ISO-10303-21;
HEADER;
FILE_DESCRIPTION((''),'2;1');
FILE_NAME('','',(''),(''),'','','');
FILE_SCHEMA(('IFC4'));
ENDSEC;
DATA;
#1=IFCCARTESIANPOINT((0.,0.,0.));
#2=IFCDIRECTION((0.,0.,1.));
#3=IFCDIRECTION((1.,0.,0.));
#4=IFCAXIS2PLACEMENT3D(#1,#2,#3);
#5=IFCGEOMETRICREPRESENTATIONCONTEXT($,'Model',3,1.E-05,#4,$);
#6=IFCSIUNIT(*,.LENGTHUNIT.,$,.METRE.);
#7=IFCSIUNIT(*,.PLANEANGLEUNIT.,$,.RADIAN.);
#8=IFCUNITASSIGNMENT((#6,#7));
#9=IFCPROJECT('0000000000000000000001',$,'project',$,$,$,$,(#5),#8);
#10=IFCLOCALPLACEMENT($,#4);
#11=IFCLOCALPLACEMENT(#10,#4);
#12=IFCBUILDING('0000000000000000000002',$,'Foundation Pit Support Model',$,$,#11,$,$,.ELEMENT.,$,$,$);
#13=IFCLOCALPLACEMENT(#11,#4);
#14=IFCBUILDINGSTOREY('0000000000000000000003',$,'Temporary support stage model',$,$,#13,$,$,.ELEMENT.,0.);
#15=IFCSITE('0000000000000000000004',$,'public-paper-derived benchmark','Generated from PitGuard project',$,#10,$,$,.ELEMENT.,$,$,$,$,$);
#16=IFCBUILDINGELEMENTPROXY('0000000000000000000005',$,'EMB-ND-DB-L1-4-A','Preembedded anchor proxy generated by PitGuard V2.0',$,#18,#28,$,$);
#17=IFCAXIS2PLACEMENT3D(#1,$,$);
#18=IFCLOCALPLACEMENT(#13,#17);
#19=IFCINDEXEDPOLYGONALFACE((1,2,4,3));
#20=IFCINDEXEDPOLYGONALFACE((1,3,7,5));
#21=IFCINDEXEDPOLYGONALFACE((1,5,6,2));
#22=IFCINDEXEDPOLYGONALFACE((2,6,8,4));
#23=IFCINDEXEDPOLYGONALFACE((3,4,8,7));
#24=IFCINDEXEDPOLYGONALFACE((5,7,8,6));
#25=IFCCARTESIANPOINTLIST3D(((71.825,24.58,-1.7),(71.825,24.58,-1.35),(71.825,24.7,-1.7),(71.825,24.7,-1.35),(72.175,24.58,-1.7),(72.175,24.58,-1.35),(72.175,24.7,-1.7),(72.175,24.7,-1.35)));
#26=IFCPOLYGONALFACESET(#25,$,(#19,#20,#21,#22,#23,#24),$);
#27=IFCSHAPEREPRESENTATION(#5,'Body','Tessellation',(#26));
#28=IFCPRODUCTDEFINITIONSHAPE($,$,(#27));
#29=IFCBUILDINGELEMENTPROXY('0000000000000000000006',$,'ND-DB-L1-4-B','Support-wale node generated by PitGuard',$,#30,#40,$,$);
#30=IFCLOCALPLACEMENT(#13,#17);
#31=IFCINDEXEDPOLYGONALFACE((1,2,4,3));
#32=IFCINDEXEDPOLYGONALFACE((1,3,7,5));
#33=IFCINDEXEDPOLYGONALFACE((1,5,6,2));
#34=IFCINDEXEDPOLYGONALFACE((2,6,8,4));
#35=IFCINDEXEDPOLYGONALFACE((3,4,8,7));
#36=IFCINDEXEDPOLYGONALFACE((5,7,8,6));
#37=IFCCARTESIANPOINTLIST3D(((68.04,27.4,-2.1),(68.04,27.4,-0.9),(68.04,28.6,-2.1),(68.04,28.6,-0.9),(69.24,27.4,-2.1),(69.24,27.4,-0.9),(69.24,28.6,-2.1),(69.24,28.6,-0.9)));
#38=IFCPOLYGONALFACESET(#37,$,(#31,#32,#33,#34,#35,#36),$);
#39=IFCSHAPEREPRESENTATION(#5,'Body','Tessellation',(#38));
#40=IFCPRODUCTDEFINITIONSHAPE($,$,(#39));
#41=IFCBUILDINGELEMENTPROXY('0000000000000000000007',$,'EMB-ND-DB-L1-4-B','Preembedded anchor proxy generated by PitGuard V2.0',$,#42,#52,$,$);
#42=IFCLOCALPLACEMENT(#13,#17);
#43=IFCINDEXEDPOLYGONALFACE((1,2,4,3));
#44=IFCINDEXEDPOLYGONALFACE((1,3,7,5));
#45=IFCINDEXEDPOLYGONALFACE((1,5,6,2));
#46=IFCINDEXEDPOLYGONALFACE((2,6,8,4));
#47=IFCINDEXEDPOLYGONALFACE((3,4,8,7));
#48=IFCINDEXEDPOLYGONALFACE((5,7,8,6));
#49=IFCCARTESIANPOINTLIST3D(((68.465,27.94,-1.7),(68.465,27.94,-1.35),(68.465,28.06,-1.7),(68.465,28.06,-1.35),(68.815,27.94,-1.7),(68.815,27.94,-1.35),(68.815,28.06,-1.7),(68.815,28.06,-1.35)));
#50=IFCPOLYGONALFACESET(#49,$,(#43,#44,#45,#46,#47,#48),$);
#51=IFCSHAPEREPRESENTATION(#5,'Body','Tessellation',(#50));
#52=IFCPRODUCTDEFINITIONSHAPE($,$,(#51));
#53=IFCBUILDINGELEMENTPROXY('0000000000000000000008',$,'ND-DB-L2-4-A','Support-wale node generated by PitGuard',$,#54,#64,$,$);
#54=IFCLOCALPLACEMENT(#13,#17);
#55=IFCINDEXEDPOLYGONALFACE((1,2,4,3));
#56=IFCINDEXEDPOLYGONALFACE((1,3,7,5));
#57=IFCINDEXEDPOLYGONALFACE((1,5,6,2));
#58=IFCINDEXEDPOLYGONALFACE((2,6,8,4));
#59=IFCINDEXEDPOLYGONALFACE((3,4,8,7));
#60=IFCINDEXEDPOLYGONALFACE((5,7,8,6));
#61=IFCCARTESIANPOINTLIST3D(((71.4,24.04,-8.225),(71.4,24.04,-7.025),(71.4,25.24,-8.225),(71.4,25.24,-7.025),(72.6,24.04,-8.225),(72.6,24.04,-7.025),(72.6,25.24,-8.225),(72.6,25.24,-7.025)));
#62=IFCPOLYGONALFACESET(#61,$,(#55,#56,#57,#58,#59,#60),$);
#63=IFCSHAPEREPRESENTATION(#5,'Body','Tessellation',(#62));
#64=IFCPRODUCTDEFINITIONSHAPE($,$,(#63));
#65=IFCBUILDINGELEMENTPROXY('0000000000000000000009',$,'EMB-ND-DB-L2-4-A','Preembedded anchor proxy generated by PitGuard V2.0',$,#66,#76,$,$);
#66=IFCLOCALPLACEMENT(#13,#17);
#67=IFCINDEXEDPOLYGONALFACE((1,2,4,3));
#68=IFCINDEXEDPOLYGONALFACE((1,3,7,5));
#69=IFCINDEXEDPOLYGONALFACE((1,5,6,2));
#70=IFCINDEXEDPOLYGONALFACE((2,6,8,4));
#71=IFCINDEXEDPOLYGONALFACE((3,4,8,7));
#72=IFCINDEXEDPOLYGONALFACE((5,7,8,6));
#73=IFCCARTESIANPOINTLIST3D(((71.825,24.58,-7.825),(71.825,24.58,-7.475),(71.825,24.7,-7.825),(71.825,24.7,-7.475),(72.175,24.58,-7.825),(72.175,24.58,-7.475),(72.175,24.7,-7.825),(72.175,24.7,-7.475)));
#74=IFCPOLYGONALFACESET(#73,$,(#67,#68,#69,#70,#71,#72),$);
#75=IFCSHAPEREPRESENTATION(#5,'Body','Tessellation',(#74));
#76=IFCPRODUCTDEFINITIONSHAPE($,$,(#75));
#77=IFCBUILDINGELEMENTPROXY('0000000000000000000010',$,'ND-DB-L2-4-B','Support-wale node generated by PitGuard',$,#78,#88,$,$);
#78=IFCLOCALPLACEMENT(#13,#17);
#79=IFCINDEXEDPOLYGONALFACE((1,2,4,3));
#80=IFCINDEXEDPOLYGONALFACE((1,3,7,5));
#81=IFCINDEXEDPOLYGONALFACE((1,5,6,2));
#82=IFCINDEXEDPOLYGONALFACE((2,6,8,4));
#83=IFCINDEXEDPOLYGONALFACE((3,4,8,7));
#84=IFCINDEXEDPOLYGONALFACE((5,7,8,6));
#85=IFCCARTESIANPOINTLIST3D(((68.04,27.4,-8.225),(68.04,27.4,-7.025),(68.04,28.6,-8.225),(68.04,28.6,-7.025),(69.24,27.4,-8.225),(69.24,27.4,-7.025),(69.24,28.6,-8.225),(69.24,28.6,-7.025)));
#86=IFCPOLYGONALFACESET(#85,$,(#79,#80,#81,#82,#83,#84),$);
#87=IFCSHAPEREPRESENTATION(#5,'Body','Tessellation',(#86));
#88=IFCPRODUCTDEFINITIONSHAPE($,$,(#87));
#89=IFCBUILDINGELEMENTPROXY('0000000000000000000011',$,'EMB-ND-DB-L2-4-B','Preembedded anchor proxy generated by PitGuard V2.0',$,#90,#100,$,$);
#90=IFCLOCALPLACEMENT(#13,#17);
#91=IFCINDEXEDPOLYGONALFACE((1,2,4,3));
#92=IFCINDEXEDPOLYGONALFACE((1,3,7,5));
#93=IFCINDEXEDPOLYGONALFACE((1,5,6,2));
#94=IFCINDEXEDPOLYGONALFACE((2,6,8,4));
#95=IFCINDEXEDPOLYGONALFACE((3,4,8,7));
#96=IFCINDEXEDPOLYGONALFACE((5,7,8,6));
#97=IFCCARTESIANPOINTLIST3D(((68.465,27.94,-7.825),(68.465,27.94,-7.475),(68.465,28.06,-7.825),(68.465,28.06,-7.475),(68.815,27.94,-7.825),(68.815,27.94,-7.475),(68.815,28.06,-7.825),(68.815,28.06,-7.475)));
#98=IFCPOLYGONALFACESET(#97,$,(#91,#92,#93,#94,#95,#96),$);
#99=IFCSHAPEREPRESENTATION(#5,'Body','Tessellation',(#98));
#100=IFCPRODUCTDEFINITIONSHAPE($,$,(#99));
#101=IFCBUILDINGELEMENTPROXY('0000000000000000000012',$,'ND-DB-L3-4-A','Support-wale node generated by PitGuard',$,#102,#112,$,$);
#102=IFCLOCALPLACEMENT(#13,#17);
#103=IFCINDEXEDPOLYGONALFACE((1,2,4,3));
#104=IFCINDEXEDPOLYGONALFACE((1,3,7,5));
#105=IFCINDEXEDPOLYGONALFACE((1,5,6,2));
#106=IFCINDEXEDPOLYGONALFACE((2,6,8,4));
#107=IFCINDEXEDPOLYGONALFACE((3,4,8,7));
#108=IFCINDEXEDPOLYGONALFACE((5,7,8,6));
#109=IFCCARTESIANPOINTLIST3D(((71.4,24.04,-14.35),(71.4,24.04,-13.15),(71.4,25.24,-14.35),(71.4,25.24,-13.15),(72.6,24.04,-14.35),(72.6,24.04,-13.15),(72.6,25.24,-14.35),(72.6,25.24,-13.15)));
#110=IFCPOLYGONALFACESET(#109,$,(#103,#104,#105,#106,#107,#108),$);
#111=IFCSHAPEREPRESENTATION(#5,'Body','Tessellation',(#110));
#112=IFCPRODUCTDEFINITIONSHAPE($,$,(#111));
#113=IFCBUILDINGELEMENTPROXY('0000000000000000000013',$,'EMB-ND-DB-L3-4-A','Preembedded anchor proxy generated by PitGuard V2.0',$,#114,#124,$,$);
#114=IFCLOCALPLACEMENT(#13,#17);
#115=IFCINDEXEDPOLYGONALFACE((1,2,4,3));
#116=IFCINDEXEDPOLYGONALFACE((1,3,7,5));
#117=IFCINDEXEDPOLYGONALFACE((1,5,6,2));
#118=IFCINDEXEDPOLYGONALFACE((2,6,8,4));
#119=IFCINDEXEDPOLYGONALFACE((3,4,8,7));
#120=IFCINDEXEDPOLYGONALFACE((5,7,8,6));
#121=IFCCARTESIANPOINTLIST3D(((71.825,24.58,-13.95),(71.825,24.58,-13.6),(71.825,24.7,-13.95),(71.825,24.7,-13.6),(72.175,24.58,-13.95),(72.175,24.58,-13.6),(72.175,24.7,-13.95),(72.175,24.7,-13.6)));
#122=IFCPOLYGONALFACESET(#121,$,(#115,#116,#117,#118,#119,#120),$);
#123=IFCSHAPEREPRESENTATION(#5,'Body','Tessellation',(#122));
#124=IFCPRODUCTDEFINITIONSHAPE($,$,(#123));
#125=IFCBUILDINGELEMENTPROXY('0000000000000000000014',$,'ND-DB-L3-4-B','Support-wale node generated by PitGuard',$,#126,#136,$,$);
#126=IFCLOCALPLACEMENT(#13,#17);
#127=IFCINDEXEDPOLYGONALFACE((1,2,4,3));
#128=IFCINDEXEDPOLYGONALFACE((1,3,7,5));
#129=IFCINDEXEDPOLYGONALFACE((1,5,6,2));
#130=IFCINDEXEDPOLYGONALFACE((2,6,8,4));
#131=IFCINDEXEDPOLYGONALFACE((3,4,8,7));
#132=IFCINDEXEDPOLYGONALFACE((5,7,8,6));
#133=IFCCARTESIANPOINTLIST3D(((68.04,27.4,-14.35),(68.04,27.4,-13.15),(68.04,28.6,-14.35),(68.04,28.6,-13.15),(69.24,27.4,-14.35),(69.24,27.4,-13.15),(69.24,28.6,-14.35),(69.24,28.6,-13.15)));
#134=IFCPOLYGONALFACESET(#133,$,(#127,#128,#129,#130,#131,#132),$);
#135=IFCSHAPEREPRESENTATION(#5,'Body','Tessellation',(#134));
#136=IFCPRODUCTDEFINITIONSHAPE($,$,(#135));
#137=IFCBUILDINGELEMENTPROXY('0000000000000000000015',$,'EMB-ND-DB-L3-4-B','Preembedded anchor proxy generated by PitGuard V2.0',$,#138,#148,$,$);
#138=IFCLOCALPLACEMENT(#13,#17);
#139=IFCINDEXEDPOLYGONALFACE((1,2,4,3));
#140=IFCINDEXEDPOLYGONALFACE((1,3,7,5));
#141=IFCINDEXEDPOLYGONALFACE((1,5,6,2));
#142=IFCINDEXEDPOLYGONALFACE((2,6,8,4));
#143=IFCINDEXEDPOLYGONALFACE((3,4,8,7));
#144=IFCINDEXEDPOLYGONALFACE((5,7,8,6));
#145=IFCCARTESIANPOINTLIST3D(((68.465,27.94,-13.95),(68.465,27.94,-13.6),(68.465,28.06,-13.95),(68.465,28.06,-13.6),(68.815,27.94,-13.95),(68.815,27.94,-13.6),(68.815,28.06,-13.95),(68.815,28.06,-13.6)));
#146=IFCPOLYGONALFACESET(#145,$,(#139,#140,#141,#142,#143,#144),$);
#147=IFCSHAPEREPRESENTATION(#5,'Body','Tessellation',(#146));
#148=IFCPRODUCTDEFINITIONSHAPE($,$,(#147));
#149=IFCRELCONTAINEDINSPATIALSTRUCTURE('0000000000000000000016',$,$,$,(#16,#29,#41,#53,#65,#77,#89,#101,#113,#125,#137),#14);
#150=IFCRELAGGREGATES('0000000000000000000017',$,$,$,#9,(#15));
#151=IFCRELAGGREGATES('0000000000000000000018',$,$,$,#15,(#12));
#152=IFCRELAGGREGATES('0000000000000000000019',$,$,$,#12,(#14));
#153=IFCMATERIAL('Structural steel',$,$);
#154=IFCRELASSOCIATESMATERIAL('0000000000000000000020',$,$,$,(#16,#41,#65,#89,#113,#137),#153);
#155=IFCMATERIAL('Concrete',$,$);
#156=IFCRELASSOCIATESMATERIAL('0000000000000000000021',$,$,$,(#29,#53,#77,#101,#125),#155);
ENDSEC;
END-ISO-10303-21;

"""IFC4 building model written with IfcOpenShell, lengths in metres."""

from ifc_helpers import new_model, si_unit, frame, origin_with_axes, origin_2d, place, context, project, spatial, rectangle, extrude, material, element, save


model = new_model("IFC4")

# Units and contexts
model_context = context("Model", 3, precision=1e-05, world=origin_with_axes())
ifc_project = project(units=[si_unit("LENGTHUNIT", "METRE"), si_unit("PLANEANGLEUNIT", "RADIAN")], contexts=[model_context])

# Site, building, storey
site_placement = place(None, origin_with_axes())
site = spatial("IfcSite", under=ifc_project, at=site_placement, Name="public-paper-derived benchmark", Description="Generated from PitGuard project", CompositionType="ELEMENT")
building_placement = place(site_placement, origin_with_axes())
building = spatial("IfcBuilding", under=site, at=building_placement, Name="Foundation Pit Support Model", CompositionType="ELEMENT")
storey_placement = place(building_placement, origin_with_axes())
storey = spatial("IfcBuildingStorey", under=building, at=storey_placement, Name="Temporary support stage model", CompositionType="ELEMENT", Elevation=0.0)

# Shared definitions
ifc_material_1 = material(Name="Concrete")

# Shared definitions
ifc_material_2 = material(Name="Structural steel")

# Building element proxies
proxy_1_placement = place(storey_placement, frame((72.0, 24.64, -1.7), z_axis=(0.0, 0.0, 1.0), x_axis=(1.0, 0.0, 0.0)))
element("IfcBuildingElementProxy", 1, at=proxy_1_placement, inside=storey, material=ifc_material_2, Name="EMB-ND-DB-L1-4-A", Description="Preembedded anchor proxy generated by PitGuard V2.0", context=model_context, shape_type="SweptSolid", body=[
    extrude(rectangle(XDim=0.35, YDim=0.12, at=origin_2d()), origin_with_axes(), (0.0, 0.0, 1.0), 0.35),
])
proxy_2_placement = place(storey_placement, frame((68.64, 28.0, -2.1), z_axis=(0.0, 0.0, 1.0), x_axis=(1.0, 0.0, 0.0)))
element("IfcBuildingElementProxy", 2, at=proxy_2_placement, inside=storey, material=ifc_material_1, Name="ND-DB-L1-4-B", Description="Support-wale node generated by PitGuard", context=model_context, shape_type="SweptSolid", body=[
    extrude(rectangle(XDim=1.2, YDim=1.2, at=origin_2d()), origin_with_axes(), (0.0, 0.0, 1.0), 1.2),
])
proxy_3_placement = place(storey_placement, frame((68.64, 28.0, -1.7), z_axis=(0.0, 0.0, 1.0), x_axis=(1.0, 0.0, 0.0)))
element("IfcBuildingElementProxy", 3, at=proxy_3_placement, inside=storey, material=ifc_material_2, Name="EMB-ND-DB-L1-4-B", Description="Preembedded anchor proxy generated by PitGuard V2.0", context=model_context, shape_type="SweptSolid", body=[
    extrude(rectangle(XDim=0.35, YDim=0.12, at=origin_2d()), origin_with_axes(), (0.0, 0.0, 1.0), 0.35),
])
proxy_4_placement = place(storey_placement, frame((72.0, 24.64, -8.225), z_axis=(0.0, 0.0, 1.0), x_axis=(1.0, 0.0, 0.0)))
element("IfcBuildingElementProxy", 4, at=proxy_4_placement, inside=storey, material=ifc_material_1, Name="ND-DB-L2-4-A", Description="Support-wale node generated by PitGuard", context=model_context, shape_type="SweptSolid", body=[
    extrude(rectangle(XDim=1.2, YDim=1.2, at=origin_2d()), origin_with_axes(), (0.0, 0.0, 1.0), 1.2),
])
proxy_5_placement = place(storey_placement, frame((72.0, 24.64, -7.825), z_axis=(0.0, 0.0, 1.0), x_axis=(1.0, 0.0, 0.0)))
element("IfcBuildingElementProxy", 5, at=proxy_5_placement, inside=storey, material=ifc_material_2, Name="EMB-ND-DB-L2-4-A", Description="Preembedded anchor proxy generated by PitGuard V2.0", context=model_context, shape_type="SweptSolid", body=[
    extrude(rectangle(XDim=0.35, YDim=0.12, at=origin_2d()), origin_with_axes(), (0.0, 0.0, 1.0), 0.35),
])
proxy_6_placement = place(storey_placement, frame((68.64, 28.0, -8.225), z_axis=(0.0, 0.0, 1.0), x_axis=(1.0, 0.0, 0.0)))
element("IfcBuildingElementProxy", 6, at=proxy_6_placement, inside=storey, material=ifc_material_1, Name="ND-DB-L2-4-B", Description="Support-wale node generated by PitGuard", context=model_context, shape_type="SweptSolid", body=[
    extrude(rectangle(XDim=1.2, YDim=1.2, at=origin_2d()), origin_with_axes(), (0.0, 0.0, 1.0), 1.2),
])
proxy_7_placement = place(storey_placement, frame((68.64, 28.0, -7.825), z_axis=(0.0, 0.0, 1.0), x_axis=(1.0, 0.0, 0.0)))
element("IfcBuildingElementProxy", 7, at=proxy_7_placement, inside=storey, material=ifc_material_2, Name="EMB-ND-DB-L2-4-B", Description="Preembedded anchor proxy generated by PitGuard V2.0", context=model_context, shape_type="SweptSolid", body=[
    extrude(rectangle(XDim=0.35, YDim=0.12, at=origin_2d()), origin_with_axes(), (0.0, 0.0, 1.0), 0.35),
])
proxy_8_placement = place(storey_placement, frame((72.0, 24.64, -14.35), z_axis=(0.0, 0.0, 1.0), x_axis=(1.0, 0.0, 0.0)))
element("IfcBuildingElementProxy", 8, at=proxy_8_placement, inside=storey, material=ifc_material_1, Name="ND-DB-L3-4-A", Description="Support-wale node generated by PitGuard", context=model_context, shape_type="SweptSolid", body=[
    extrude(rectangle(XDim=1.2, YDim=1.2, at=origin_2d()), origin_with_axes(), (0.0, 0.0, 1.0), 1.2),
])
proxy_9_placement = place(storey_placement, frame((72.0, 24.64, -13.95), z_axis=(0.0, 0.0, 1.0), x_axis=(1.0, 0.0, 0.0)))
element("IfcBuildingElementProxy", 9, at=proxy_9_placement, inside=storey, material=ifc_material_2, Name="EMB-ND-DB-L3-4-A", Description="Preembedded anchor proxy generated by PitGuard V2.0", context=model_context, shape_type="SweptSolid", body=[
    extrude(rectangle(XDim=0.35, YDim=0.12, at=origin_2d()), origin_with_axes(), (0.0, 0.0, 1.0), 0.35),
])
proxy_10_placement = place(storey_placement, frame((68.64, 28.0, -14.35), z_axis=(0.0, 0.0, 1.0), x_axis=(1.0, 0.0, 0.0)))
element("IfcBuildingElementProxy", 10, at=proxy_10_placement, inside=storey, material=ifc_material_1, Name="ND-DB-L3-4-B", Description="Support-wale node generated by PitGuard", context=model_context, shape_type="SweptSolid", body=[
    extrude(rectangle(XDim=1.2, YDim=1.2, at=origin_2d()), origin_with_axes(), (0.0, 0.0, 1.0), 1.2),
])
proxy_11_placement = place(storey_placement, frame((68.64, 28.0, -13.95), z_axis=(0.0, 0.0, 1.0), x_axis=(1.0, 0.0, 0.0)))
element("IfcBuildingElementProxy", 11, at=proxy_11_placement, inside=storey, material=ifc_material_2, Name="EMB-ND-DB-L3-4-B", Description="Preembedded anchor proxy generated by PitGuard V2.0", context=model_context, shape_type="SweptSolid", body=[
    extrude(rectangle(XDim=0.35, YDim=0.12, at=origin_2d()), origin_with_axes(), (0.0, 0.0, 1.0), 0.35),
])

save(model, "model.ifc")
